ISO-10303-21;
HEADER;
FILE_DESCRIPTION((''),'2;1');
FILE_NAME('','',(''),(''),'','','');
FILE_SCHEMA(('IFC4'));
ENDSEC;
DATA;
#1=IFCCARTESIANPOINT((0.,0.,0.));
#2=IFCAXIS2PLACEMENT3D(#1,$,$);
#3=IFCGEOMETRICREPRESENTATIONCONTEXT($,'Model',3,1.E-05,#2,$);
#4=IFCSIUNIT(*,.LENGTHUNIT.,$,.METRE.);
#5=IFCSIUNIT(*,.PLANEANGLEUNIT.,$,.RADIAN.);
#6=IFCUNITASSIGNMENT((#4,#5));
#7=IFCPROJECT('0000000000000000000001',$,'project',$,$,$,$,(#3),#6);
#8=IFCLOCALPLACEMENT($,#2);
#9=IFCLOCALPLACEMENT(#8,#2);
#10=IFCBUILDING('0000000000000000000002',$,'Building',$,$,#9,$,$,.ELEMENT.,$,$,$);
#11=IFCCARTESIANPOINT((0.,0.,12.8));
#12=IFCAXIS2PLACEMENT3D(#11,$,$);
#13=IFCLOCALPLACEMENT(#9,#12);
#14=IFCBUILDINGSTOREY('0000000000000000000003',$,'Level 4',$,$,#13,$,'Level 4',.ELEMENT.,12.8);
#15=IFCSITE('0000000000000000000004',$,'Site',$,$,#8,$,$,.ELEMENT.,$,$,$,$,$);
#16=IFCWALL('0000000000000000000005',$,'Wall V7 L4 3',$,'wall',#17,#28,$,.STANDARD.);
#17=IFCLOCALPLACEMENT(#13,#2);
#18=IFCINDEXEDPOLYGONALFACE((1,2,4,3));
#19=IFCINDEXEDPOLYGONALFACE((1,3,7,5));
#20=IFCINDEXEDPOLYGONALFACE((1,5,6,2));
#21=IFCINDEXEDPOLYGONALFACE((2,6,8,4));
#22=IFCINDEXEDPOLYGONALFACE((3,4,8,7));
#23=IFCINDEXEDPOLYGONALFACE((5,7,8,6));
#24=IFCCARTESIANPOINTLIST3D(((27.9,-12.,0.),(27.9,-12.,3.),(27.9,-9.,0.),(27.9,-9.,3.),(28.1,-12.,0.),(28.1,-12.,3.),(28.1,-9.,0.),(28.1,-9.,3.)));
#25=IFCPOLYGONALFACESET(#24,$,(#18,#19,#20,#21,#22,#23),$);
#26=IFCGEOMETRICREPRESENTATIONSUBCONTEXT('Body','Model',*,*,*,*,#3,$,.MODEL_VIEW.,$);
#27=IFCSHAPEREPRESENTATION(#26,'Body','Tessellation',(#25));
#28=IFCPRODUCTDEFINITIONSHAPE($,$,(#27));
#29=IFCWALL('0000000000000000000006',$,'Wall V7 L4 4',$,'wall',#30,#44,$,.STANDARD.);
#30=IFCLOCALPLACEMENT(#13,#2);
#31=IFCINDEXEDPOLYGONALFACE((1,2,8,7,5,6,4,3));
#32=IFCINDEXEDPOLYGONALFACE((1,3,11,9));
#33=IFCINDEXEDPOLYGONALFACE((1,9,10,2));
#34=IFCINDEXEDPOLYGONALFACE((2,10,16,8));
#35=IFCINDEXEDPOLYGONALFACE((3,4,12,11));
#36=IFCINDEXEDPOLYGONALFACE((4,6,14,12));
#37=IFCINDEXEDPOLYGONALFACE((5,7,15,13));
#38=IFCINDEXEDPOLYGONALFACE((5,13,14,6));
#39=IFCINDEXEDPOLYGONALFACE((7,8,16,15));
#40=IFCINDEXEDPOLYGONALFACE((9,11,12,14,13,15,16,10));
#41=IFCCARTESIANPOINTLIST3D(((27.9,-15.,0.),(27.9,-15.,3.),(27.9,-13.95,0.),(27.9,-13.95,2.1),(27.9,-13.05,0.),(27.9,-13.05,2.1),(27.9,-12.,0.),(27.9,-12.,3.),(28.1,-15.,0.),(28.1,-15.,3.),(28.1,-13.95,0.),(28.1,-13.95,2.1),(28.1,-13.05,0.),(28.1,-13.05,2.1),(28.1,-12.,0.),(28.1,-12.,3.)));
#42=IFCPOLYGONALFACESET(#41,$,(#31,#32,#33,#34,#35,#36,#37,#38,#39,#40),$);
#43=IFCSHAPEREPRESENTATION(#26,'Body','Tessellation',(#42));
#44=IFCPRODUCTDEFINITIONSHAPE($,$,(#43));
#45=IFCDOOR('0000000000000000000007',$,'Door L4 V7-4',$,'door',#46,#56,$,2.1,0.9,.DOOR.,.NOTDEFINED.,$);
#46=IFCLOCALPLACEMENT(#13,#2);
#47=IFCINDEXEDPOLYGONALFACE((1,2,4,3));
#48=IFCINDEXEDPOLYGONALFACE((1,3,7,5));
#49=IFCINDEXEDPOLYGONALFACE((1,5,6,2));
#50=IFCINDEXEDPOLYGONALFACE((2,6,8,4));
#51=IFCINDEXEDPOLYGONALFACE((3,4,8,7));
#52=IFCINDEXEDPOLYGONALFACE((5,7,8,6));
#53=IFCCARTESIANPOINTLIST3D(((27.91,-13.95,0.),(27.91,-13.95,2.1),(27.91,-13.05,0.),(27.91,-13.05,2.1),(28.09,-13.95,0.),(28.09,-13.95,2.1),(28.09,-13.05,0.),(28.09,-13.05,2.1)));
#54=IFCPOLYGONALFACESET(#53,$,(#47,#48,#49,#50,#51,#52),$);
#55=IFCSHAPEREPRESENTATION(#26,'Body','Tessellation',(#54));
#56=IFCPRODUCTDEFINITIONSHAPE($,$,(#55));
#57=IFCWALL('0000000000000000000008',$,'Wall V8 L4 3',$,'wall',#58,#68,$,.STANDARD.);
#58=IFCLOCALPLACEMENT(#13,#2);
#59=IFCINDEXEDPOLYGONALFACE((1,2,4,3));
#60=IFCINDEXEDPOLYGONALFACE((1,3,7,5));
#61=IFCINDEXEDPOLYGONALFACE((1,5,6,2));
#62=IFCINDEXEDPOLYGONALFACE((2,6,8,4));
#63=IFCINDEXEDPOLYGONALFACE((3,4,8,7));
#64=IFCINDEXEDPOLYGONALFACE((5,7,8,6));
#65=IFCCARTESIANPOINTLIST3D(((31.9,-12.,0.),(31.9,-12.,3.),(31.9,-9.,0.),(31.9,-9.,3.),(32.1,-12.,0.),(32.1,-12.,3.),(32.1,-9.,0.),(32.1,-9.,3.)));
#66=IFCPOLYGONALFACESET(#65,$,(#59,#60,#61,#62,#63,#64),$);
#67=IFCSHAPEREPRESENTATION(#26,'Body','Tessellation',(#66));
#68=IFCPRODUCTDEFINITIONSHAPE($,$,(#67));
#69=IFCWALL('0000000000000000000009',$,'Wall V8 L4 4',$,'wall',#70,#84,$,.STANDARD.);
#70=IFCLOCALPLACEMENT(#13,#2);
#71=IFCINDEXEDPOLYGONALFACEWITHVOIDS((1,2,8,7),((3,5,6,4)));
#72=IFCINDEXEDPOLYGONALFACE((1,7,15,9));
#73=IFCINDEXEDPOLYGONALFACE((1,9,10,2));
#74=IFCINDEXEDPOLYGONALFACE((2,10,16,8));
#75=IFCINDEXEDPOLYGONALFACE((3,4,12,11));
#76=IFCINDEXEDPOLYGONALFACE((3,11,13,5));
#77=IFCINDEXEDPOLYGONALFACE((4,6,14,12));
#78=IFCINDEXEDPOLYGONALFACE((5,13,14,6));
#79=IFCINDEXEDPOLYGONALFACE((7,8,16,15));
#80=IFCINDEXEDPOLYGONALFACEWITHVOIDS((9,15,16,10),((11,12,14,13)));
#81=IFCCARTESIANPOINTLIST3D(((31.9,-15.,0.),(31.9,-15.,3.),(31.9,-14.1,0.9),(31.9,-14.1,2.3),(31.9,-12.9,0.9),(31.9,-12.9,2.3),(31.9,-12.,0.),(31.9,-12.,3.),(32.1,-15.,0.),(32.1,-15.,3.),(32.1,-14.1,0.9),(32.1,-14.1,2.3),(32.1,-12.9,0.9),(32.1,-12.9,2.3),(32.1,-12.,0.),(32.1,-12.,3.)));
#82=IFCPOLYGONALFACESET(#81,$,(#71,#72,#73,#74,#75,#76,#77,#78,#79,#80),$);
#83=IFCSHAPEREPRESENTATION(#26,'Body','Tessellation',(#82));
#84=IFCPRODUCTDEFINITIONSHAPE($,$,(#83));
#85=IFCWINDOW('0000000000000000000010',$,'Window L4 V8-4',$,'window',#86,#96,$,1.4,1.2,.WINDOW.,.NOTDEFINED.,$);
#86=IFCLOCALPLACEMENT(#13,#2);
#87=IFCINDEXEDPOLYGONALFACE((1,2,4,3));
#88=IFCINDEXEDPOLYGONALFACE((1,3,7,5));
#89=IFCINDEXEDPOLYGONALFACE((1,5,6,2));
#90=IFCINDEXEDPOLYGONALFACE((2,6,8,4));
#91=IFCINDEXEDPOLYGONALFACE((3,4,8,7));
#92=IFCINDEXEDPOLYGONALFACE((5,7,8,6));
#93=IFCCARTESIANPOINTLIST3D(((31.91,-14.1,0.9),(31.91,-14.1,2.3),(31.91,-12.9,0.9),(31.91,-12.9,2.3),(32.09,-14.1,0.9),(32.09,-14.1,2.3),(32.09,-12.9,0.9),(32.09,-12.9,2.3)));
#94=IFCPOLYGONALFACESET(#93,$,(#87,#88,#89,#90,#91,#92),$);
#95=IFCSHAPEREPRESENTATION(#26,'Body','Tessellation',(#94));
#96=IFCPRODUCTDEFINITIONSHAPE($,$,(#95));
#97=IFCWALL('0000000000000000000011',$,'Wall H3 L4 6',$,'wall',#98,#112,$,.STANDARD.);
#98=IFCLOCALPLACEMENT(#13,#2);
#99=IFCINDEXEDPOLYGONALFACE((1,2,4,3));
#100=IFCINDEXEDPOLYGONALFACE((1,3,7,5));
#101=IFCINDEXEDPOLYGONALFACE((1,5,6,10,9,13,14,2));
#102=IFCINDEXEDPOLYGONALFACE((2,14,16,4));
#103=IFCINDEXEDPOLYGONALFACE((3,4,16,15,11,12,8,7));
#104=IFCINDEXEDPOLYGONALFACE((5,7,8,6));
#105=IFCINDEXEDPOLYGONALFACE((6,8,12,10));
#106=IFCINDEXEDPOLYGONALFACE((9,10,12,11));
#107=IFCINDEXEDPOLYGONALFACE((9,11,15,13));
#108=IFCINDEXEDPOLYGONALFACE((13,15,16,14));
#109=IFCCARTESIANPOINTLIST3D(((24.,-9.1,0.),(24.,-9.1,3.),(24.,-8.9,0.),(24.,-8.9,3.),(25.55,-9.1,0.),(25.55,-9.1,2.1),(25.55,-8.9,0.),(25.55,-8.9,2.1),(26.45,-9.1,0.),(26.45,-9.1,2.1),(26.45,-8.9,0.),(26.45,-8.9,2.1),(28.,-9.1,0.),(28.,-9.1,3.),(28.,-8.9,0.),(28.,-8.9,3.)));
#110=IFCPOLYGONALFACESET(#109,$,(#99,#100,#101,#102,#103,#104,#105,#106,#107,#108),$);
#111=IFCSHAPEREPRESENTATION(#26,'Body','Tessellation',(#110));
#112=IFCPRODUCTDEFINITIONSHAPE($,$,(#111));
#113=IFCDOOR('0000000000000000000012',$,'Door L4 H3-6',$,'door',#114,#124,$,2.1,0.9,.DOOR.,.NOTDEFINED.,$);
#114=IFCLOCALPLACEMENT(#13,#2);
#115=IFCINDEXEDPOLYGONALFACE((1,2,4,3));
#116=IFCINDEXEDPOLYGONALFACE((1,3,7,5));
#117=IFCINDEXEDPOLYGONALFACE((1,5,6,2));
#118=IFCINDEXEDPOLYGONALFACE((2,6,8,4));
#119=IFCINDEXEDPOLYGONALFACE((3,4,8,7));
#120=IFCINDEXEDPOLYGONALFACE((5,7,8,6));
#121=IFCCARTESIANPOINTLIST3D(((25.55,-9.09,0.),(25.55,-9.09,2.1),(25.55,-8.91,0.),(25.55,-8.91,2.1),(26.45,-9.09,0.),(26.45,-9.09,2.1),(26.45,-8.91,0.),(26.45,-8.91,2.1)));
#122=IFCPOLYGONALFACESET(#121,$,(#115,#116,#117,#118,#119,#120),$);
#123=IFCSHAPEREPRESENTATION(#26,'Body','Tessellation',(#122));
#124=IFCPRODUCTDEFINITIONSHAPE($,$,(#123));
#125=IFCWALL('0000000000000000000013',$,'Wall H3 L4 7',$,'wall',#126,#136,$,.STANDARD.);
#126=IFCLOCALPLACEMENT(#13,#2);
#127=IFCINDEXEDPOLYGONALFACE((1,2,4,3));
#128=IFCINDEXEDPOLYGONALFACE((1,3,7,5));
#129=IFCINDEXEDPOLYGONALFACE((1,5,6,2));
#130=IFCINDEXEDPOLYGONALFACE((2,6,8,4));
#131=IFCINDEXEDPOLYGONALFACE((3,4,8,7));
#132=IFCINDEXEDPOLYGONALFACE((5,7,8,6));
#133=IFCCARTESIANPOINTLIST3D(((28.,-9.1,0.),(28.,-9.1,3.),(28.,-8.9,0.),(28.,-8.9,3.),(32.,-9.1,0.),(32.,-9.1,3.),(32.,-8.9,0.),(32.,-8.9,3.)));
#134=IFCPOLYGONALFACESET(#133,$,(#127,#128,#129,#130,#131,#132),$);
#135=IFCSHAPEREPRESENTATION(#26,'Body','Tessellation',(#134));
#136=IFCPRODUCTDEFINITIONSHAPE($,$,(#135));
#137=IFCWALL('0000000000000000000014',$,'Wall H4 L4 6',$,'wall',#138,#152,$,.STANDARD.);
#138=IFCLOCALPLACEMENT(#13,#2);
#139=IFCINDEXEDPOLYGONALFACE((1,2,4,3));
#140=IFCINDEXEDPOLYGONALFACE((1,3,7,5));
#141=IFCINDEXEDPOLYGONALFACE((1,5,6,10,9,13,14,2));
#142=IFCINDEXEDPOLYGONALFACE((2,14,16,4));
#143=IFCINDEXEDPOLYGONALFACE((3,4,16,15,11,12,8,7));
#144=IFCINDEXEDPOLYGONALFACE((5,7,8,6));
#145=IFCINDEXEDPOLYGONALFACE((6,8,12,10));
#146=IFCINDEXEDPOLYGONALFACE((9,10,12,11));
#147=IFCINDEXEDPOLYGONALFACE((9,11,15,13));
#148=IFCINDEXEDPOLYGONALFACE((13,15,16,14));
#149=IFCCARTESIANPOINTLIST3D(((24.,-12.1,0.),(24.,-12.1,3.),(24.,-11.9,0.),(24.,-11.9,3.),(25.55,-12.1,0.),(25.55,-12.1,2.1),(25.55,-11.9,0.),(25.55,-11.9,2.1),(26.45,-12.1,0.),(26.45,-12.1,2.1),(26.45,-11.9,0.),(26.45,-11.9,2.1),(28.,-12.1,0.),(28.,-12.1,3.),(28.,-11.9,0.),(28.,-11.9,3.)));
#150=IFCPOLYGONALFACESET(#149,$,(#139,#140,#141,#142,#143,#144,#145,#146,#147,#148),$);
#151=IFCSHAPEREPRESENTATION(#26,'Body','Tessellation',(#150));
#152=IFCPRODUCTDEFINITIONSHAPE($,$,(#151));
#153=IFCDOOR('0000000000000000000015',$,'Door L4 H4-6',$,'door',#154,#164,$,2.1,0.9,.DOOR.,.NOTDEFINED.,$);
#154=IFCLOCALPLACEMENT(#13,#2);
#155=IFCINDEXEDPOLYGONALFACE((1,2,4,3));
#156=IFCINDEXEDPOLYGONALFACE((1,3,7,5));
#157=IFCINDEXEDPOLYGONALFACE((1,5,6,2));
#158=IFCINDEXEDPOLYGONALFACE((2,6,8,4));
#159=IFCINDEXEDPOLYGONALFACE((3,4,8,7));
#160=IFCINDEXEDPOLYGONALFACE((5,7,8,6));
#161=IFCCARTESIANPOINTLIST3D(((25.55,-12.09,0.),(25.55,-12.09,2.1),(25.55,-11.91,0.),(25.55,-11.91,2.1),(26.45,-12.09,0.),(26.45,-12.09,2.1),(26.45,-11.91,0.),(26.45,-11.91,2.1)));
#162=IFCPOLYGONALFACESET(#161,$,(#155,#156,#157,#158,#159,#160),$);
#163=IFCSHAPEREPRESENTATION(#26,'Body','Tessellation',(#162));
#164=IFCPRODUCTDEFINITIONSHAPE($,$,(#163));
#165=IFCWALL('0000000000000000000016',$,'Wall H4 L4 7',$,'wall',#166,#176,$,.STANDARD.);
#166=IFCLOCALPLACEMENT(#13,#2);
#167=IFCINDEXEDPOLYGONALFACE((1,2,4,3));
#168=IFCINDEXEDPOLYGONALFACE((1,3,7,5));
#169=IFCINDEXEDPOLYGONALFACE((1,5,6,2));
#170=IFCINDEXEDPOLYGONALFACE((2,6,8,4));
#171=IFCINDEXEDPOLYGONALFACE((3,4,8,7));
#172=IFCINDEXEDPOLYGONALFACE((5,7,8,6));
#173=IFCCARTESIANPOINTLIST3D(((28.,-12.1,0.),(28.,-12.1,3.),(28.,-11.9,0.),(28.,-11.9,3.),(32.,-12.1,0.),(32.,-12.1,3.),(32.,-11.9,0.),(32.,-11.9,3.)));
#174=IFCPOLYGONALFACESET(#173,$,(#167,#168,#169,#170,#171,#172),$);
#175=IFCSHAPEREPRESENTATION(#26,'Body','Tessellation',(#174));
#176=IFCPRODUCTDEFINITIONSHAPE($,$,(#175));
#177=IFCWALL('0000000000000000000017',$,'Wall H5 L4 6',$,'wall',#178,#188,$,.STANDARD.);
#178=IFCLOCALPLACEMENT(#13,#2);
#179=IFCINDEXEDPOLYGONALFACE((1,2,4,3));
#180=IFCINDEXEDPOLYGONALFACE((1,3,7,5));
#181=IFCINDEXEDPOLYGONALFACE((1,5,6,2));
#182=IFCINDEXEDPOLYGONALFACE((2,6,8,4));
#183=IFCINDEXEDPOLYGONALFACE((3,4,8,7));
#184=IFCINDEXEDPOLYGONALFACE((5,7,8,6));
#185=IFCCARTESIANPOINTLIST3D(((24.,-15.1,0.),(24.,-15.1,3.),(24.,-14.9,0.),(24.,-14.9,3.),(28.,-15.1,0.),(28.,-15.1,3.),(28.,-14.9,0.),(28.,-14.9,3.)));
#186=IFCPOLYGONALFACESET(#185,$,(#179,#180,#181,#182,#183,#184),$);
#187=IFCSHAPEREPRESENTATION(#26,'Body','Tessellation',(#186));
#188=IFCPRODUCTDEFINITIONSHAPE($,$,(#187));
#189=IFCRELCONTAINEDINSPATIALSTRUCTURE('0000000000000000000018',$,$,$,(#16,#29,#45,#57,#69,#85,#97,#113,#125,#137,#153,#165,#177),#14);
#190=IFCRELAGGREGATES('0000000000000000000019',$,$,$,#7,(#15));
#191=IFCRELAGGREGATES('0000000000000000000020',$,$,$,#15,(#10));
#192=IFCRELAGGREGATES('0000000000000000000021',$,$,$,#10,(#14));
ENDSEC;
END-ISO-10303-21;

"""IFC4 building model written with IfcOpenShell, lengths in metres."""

from ifc_helpers import new_model, si_unit, frame, frame_2d, origin, origin_2d, place, context, subcontext, project, spatial, rectangle, extrude, element, fill, save


model = new_model("IFC4")

# Units and contexts
model_context = context("Model", 3, precision=1e-05, world=origin())
body_context = subcontext(model_context, "Body", "Model", "MODEL_VIEW")
ifc_project = project(units=[si_unit("LENGTHUNIT", "METRE"), si_unit("PLANEANGLEUNIT", "RADIAN")], contexts=[model_context])

# Site, building, storey
site_placement = place(None, origin())
site = spatial("IfcSite", under=ifc_project, at=site_placement, Name="Site", CompositionType="ELEMENT")
building_placement = place(site_placement, origin())
building = spatial("IfcBuilding", under=site, at=building_placement, Name="Building", CompositionType="ELEMENT")
storey_placement = place(building_placement, frame((0.0, 0.0, 12.8)))
storey = spatial("IfcBuildingStorey", under=building, at=storey_placement, Name="Level 4", LongName="Level 4", CompositionType="ELEMENT", Elevation=12.8)

# Wall
wall_1_placement = place(storey_placement, frame((28.0, -9.0, 0.0), z_axis=(0.0, 0.0, 1.0), x_axis=(0.0, -1.0, 0.0)))
element("IfcWall", 1, at=wall_1_placement, inside=storey, Name="Wall V7 L4 3", ObjectType="wall", PredefinedType="STANDARD", context=body_context, shape_type="SweptSolid", body=[
    extrude(rectangle(XDim=3.0, YDim=0.2, at=frame_2d((1.5, 0.0))), origin(), (0.0, 0.0, 1.0), 3.0),
])

# Wall, opening, door
wall_2_placement = place(storey_placement, frame((28.0, -12.0, 0.0), z_axis=(0.0, 0.0, 1.0), x_axis=(0.0, -1.0, 0.0)))
wall_2 = element("IfcWall", 2, at=wall_2_placement, inside=storey, Name="Wall V7 L4 4", ObjectType="wall", PredefinedType="STANDARD", context=body_context, shape_type="SweptSolid", body=[
    extrude(rectangle(XDim=3.0, YDim=0.2, at=frame_2d((1.5, 0.0))), origin(), (0.0, 0.0, 1.0), 3.0),
])
opening_1_placement = place(storey_placement, frame((28.0, -13.5, 0.0), z_axis=(0.0, 0.0, 1.0), x_axis=(0.0, -1.0, 0.0)))
opening_1 = element("IfcOpeningElement", 3, at=opening_1_placement, cuts=wall_2, ObjectType="Opening", PredefinedType="OPENING", context=body_context, shape_type="SweptSolid", body=[
    extrude(rectangle(XDim=0.9, YDim=0.22, at=origin_2d()), origin(), (0.0, 0.0, 1.0), 2.1),
])
door_1_placement = place(storey_placement, frame((28.0, -13.5, 0.0), z_axis=(0.0, 0.0, 1.0), x_axis=(0.0, -1.0, 0.0)))
door_1 = element("IfcDoor", 4, at=door_1_placement, inside=storey, Name="Door L4 V7-4", ObjectType="door", OperationType="NOTDEFINED", OverallHeight=2.1, OverallWidth=0.9, PredefinedType="DOOR", context=body_context, shape_type="SweptSolid", body=[
    extrude(rectangle(XDim=0.9, YDim=0.18, at=origin_2d()), origin(), (0.0, 0.0, 1.0), 2.1),
])
fill(opening_1, door_1)

# Wall
wall_3_placement = place(storey_placement, frame((32.0, -9.0, 0.0), z_axis=(0.0, 0.0, 1.0), x_axis=(0.0, -1.0, 0.0)))
element("IfcWall", 5, at=wall_3_placement, inside=storey, Name="Wall V8 L4 3", ObjectType="wall", PredefinedType="STANDARD", context=body_context, shape_type="SweptSolid", body=[
    extrude(rectangle(XDim=3.0, YDim=0.2, at=frame_2d((1.5, 0.0))), origin(), (0.0, 0.0, 1.0), 3.0),
])

# Wall, opening, window
wall_4_placement = place(storey_placement, frame((32.0, -12.0, 0.0), z_axis=(0.0, 0.0, 1.0), x_axis=(0.0, -1.0, 0.0)))
wall_4 = element("IfcWall", 6, at=wall_4_placement, inside=storey, Name="Wall V8 L4 4", ObjectType="wall", PredefinedType="STANDARD", context=body_context, shape_type="SweptSolid", body=[
    extrude(rectangle(XDim=3.0, YDim=0.2, at=frame_2d((1.5, 0.0))), origin(), (0.0, 0.0, 1.0), 3.0),
])
opening_2_placement = place(storey_placement, frame((32.0, -13.5, 0.9), z_axis=(0.0, 0.0, 1.0), x_axis=(0.0, -1.0, 0.0)))
opening_2 = element("IfcOpeningElement", 7, at=opening_2_placement, cuts=wall_4, ObjectType="Opening", PredefinedType="OPENING", context=body_context, shape_type="SweptSolid", body=[
    extrude(rectangle(XDim=1.2, YDim=0.22, at=origin_2d()), origin(), (0.0, 0.0, 1.0), 1.4),
])
window_1_placement = place(storey_placement, frame((32.0, -13.5, 0.9), z_axis=(0.0, 0.0, 1.0), x_axis=(0.0, -1.0, 0.0)))
window_1 = element("IfcWindow", 8, at=window_1_placement, inside=storey, Name="Window L4 V8-4", ObjectType="window", OverallHeight=1.4, OverallWidth=1.2, PartitioningType="NOTDEFINED", PredefinedType="WINDOW", context=body_context, shape_type="SweptSolid", body=[
    extrude(rectangle(XDim=1.2, YDim=0.18, at=origin_2d()), origin(), (0.0, 0.0, 1.0), 1.4),
])
fill(opening_2, window_1)

# Wall, opening, door
wall_5_placement = place(storey_placement, frame((24.0, -9.0, 0.0), z_axis=(0.0, 0.0, 1.0), x_axis=(1.0, 0.0, 0.0)))
wall_5 = element("IfcWall", 9, at=wall_5_placement, inside=storey, Name="Wall H3 L4 6", ObjectType="wall", PredefinedType="STANDARD", context=body_context, shape_type="SweptSolid", body=[
    extrude(rectangle(XDim=4.0, YDim=0.2, at=frame_2d((2.0, 0.0))), origin(), (0.0, 0.0, 1.0), 3.0),
])
opening_3_placement = place(storey_placement, frame((26.0, -9.0, 0.0), z_axis=(0.0, 0.0, 1.0), x_axis=(1.0, 0.0, 0.0)))
opening_3 = element("IfcOpeningElement", 10, at=opening_3_placement, cuts=wall_5, ObjectType="Opening", PredefinedType="OPENING", context=body_context, shape_type="SweptSolid", body=[
    extrude(rectangle(XDim=0.9, YDim=0.22, at=origin_2d()), origin(), (0.0, 0.0, 1.0), 2.1),
])
door_2_placement = place(storey_placement, frame((26.0, -9.0, 0.0), z_axis=(0.0, 0.0, 1.0), x_axis=(1.0, 0.0, 0.0)))
door_2 = element("IfcDoor", 11, at=door_2_placement, inside=storey, Name="Door L4 H3-6", ObjectType="door", OperationType="NOTDEFINED", OverallHeight=2.1, OverallWidth=0.9, PredefinedType="DOOR", context=body_context, shape_type="SweptSolid", body=[
    extrude(rectangle(XDim=0.9, YDim=0.18, at=origin_2d()), origin(), (0.0, 0.0, 1.0), 2.1),
])
fill(opening_3, door_2)

# Wall
wall_6_placement = place(storey_placement, frame((28.0, -9.0, 0.0), z_axis=(0.0, 0.0, 1.0), x_axis=(1.0, 0.0, 0.0)))
element("IfcWall", 12, at=wall_6_placement, inside=storey, Name="Wall H3 L4 7", ObjectType="wall", PredefinedType="STANDARD", context=body_context, shape_type="SweptSolid", body=[
    extrude(rectangle(XDim=4.0, YDim=0.2, at=frame_2d((2.0, 0.0))), origin(), (0.0, 0.0, 1.0), 3.0),
])

# Wall, opening, door
wall_7_placement = place(storey_placement, frame((24.0, -12.0, 0.0), z_axis=(0.0, 0.0, 1.0), x_axis=(1.0, 0.0, 0.0)))
wall_7 = element("IfcWall", 13, at=wall_7_placement, inside=storey, Name="Wall H4 L4 6", ObjectType="wall", PredefinedType="STANDARD", context=body_context, shape_type="SweptSolid", body=[
    extrude(rectangle(XDim=4.0, YDim=0.2, at=frame_2d((2.0, 0.0))), origin(), (0.0, 0.0, 1.0), 3.0),
])
opening_4_placement = place(storey_placement, frame((26.0, -12.0, 0.0), z_axis=(0.0, 0.0, 1.0), x_axis=(1.0, 0.0, 0.0)))
opening_4 = element("IfcOpeningElement", 14, at=opening_4_placement, cuts=wall_7, ObjectType="Opening", PredefinedType="OPENING", context=body_context, shape_type="SweptSolid", body=[
    extrude(rectangle(XDim=0.9, YDim=0.22, at=origin_2d()), origin(), (0.0, 0.0, 1.0), 2.1),
])
door_3_placement = place(storey_placement, frame((26.0, -12.0, 0.0), z_axis=(0.0, 0.0, 1.0), x_axis=(1.0, 0.0, 0.0)))
door_3 = element("IfcDoor", 15, at=door_3_placement, inside=storey, Name="Door L4 H4-6", ObjectType="door", OperationType="NOTDEFINED", OverallHeight=2.1, OverallWidth=0.9, PredefinedType="DOOR", context=body_context, shape_type="SweptSolid", body=[
    extrude(rectangle(XDim=0.9, YDim=0.18, at=origin_2d()), origin(), (0.0, 0.0, 1.0), 2.1),
])
fill(opening_4, door_3)

# Walls
for number, where, z_axis, x_axis, name in (
    (16, (28.0, -12.0, 0.0), (0.0, 0.0, 1.0), (1.0, 0.0, 0.0), "Wall H4 L4 7"),
    (17, (24.0, -15.0, 0.0), (0.0, 0.0, 1.0), (1.0, 0.0, 0.0), "Wall H5 L4 6"),
):
    element("IfcWall", number, at=place(storey_placement, frame(where, z_axis=z_axis, x_axis=x_axis)), inside=storey, Name=name, ObjectType="wall", PredefinedType="STANDARD", context=body_context, shape_type="SweptSolid", body=[
        extrude(rectangle(XDim=4.0, YDim=0.2, at=frame_2d((2.0, 0.0))), origin(), (0.0, 0.0, 1.0), 3.0),
    ])

save(model, "model.ifc")
